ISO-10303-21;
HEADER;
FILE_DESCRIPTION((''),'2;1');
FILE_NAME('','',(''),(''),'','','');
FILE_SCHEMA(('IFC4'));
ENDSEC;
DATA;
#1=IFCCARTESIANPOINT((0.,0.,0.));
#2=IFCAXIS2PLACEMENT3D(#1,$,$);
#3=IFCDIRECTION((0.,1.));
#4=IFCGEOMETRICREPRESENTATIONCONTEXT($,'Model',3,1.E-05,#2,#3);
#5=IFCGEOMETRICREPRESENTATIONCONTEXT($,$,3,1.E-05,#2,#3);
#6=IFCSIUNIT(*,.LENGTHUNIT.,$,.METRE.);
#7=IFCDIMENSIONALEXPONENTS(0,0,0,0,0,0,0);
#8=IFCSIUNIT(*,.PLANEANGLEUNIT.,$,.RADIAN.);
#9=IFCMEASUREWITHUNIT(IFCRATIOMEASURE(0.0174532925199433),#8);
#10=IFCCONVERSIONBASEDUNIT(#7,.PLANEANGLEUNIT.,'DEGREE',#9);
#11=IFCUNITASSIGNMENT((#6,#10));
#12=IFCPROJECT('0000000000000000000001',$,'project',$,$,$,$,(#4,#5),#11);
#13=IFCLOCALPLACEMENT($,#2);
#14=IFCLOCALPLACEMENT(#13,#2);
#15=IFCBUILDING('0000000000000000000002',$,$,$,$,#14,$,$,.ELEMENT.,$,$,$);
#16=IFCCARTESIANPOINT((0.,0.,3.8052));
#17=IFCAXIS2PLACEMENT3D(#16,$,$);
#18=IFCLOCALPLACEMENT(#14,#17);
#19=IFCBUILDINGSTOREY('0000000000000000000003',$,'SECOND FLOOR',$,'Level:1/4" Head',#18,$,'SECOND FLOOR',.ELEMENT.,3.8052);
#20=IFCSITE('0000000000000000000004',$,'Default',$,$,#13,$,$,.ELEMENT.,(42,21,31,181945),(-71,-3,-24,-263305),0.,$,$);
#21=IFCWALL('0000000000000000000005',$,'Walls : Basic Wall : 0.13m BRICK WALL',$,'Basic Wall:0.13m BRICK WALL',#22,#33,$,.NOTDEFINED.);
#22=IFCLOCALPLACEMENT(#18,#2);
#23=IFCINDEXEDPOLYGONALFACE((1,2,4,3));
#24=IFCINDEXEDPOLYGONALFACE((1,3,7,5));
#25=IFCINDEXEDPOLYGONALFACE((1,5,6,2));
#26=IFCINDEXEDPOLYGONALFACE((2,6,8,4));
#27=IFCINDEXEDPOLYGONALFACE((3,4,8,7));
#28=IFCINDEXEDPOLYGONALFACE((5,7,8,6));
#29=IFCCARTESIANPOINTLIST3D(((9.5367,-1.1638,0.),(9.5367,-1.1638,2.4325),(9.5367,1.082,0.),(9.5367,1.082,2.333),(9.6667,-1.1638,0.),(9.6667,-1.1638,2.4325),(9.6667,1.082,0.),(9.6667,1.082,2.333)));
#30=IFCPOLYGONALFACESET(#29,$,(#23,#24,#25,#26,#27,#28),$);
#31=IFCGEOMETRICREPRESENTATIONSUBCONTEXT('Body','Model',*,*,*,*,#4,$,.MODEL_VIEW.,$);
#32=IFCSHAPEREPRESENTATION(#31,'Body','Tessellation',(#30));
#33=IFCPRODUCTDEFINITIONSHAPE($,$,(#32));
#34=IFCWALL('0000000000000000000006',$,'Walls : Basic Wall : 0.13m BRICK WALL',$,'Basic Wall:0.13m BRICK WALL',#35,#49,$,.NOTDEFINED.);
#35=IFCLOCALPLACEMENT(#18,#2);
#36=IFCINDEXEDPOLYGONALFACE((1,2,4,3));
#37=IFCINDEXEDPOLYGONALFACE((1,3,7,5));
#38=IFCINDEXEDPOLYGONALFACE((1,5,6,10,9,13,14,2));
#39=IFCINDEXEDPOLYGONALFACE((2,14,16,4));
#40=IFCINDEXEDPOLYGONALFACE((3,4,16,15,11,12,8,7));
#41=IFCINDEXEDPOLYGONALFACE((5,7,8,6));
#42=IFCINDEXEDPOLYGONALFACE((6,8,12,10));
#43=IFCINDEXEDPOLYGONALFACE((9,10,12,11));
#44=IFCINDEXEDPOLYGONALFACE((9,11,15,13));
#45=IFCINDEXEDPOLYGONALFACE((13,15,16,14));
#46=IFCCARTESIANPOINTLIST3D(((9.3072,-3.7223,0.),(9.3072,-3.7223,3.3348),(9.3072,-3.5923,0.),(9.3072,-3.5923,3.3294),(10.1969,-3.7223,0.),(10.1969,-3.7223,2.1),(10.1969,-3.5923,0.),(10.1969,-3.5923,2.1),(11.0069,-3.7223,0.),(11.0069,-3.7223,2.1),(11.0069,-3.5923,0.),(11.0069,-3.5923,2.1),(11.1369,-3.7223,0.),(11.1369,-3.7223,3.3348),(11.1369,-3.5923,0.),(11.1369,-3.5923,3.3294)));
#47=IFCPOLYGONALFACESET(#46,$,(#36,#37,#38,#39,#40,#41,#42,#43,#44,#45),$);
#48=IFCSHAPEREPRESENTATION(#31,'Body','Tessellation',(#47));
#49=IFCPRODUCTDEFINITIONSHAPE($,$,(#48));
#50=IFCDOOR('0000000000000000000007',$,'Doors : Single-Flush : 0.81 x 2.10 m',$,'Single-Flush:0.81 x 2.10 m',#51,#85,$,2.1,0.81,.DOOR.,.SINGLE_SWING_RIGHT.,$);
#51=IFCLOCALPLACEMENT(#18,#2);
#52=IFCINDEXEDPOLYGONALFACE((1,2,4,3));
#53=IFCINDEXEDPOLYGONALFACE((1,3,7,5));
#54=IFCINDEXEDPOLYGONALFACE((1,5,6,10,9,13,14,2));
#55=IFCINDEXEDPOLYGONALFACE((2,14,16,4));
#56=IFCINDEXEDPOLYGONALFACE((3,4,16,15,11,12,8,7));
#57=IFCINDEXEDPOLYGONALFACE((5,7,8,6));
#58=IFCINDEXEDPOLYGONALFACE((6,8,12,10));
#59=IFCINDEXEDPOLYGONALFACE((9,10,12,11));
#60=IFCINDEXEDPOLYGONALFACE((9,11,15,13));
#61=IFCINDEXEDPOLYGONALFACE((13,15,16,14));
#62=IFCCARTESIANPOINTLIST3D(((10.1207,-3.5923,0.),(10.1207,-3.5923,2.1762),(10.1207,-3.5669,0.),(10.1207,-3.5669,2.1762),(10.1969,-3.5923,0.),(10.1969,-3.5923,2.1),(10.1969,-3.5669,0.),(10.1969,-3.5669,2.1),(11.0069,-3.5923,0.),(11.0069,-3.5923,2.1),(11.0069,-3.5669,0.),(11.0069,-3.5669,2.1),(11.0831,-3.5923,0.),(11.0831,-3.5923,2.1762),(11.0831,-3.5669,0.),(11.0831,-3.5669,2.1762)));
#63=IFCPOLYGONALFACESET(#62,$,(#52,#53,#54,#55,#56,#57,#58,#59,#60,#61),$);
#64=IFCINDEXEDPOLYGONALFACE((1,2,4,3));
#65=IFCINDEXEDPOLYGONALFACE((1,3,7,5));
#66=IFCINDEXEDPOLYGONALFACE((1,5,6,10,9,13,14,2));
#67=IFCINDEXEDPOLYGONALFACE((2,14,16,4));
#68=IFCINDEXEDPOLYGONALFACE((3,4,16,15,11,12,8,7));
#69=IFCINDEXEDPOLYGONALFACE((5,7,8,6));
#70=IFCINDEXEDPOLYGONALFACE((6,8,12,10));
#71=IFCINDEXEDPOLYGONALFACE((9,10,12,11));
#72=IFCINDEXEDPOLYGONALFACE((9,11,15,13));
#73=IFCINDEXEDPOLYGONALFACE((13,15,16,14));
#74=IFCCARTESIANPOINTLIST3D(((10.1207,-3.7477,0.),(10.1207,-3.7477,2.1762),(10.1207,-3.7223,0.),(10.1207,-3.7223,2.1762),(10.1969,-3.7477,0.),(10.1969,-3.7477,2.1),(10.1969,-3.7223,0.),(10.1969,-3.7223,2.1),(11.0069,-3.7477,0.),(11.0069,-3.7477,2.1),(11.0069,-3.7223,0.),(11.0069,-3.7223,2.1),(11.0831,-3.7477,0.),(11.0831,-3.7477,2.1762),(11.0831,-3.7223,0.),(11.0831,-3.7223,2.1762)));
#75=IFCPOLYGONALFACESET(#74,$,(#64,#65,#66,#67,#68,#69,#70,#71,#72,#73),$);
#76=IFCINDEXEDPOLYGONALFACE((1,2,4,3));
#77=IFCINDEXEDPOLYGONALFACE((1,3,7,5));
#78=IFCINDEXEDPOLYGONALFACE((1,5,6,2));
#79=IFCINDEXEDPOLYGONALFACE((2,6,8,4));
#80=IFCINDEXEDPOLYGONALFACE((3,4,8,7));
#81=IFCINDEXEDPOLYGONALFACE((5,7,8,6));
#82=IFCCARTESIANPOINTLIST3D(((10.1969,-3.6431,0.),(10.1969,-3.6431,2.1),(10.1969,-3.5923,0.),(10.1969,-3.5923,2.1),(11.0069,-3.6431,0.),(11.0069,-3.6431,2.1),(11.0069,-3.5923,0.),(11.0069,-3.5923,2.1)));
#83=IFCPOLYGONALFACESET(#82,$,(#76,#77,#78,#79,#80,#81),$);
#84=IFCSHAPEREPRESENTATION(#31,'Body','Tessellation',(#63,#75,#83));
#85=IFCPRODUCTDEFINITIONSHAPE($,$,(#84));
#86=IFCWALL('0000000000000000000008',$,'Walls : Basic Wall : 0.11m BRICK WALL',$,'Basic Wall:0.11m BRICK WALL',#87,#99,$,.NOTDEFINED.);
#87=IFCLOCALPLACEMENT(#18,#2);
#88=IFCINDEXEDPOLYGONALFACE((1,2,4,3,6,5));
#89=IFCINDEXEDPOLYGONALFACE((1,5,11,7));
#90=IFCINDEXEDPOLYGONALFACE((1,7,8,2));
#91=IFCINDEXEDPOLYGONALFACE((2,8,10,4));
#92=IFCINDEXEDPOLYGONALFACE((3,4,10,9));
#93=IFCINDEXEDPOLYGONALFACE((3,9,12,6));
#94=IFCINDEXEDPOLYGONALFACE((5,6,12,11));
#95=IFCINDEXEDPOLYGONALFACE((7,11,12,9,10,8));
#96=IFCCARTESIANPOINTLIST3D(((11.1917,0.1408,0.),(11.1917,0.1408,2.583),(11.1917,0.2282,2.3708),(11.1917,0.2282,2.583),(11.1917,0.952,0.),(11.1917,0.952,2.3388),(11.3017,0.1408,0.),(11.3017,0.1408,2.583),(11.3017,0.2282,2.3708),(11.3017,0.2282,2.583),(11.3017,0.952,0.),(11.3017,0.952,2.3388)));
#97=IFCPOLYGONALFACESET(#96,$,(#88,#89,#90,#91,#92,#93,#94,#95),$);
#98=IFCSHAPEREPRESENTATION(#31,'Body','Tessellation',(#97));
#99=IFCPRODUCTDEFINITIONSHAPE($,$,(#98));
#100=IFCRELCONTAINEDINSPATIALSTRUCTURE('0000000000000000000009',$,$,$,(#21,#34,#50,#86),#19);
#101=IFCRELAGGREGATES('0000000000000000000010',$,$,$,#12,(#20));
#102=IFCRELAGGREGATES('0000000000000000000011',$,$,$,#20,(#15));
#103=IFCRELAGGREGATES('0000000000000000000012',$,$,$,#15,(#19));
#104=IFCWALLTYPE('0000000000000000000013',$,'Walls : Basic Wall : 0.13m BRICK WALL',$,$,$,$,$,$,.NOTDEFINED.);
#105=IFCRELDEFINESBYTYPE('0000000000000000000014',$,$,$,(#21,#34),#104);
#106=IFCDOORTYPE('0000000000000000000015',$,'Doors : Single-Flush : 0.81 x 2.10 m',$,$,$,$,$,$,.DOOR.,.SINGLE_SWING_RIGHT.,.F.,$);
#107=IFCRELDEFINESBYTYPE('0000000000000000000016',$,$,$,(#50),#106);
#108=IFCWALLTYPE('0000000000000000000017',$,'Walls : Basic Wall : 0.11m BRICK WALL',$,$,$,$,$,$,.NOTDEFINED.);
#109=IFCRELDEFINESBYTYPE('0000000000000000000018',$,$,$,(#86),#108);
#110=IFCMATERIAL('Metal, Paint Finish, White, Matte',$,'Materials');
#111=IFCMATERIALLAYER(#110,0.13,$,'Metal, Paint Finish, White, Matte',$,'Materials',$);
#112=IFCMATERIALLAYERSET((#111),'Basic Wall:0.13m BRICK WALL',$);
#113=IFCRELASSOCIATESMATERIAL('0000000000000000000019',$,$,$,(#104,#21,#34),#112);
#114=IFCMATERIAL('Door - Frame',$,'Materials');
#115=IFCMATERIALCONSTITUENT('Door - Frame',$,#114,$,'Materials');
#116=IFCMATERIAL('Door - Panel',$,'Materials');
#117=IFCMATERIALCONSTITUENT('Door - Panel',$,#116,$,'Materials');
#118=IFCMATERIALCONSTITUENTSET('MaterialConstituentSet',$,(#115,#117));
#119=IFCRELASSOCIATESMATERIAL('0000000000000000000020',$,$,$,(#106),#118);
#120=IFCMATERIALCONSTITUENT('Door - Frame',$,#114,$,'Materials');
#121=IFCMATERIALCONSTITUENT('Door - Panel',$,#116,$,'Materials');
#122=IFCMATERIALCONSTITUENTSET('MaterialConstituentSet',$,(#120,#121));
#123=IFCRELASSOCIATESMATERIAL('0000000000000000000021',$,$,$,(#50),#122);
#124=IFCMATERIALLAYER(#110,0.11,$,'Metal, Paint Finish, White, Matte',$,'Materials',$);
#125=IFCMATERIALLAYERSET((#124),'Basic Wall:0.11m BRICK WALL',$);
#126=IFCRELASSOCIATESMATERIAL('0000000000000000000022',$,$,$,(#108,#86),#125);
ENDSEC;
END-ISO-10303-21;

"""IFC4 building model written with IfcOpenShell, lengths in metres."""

from ifc_helpers import new_model, entity, si_unit, converted_unit, direction, frame, frame_2d, origin, place, context, subcontext, project, spatial, polyline, rectangle, outline, extrude, clip, bounded_halfspace, source, transform, mapped, material, layer, layer_set, layer_usage, constituent, constituent_set, type_object, type_shapes, element, fill, save


model = new_model("IFC4")

# Units and contexts
model_context = context("Model", 3, precision=1e-05, world=origin(), true_north=direction((0.0, 1.0)))
context_of_model = context(None, 3, precision=1e-05, world=origin(), true_north=direction((0.0, 1.0)))
body_context = subcontext(model_context, "Body", "Model", "MODEL_VIEW")
ifc_project = project(units=[si_unit("LENGTHUNIT", "METRE"), converted_unit("PLANEANGLEUNIT", "DEGREE", entity("IfcRatioMeasure", 0.0174532925199433), si_unit("PLANEANGLEUNIT", "RADIAN"), dimensions=[0, 0, 0, 0, 0, 0, 0])], contexts=[model_context, context_of_model])

# Site, building, storey
site_placement = place(None, origin())
site = spatial("IfcSite", under=ifc_project, at=site_placement, Name="Default", CompositionType="ELEMENT", RefLatitude=(42, 21, 31, 181945), RefLongitude=(-71, -3, -24, -263305), RefElevation=0.0)
building_placement = place(site_placement, origin())
building = spatial("IfcBuilding", under=site, at=building_placement, CompositionType="ELEMENT")
storey_placement = place(building_placement, frame((0.0, 0.0, 3.8052)))
storey = spatial("IfcBuildingStorey", under=building, at=storey_placement, Name="SECOND FLOOR", ObjectType="Level:1/4\" Head", LongName="SECOND FLOOR", CompositionType="ELEMENT", Elevation=3.8052)

# Wall
ifc_material_1 = material(Name="Metal, Paint Finish, White, Matte", Category="Materials")
ifc_layer_1 = layer(ifc_material_1, 0.13, Name="Metal, Paint Finish, White, Matte", Category="Materials")
ifc_layer_set_1 = layer_set([ifc_layer_1], Name="Basic Wall:0.13m BRICK WALL")
ifc_layer_usage_1 = layer_usage(ifc_layer_set_1, "AXIS2", "NEGATIVE", 0.065)
wall_type_1 = type_object("IfcWallType", Name="Walls : Basic Wall : 0.13m BRICK WALL", PredefinedType="NOTDEFINED", material=ifc_layer_set_1)
wall_1_placement = place(storey_placement, frame((9.6017, 1.082, 0.0), z_axis=(0.0, 0.0, 1.0), x_axis=(0.0, -1.0, 0.0)))
element("IfcWall", 1, at=wall_1_placement, inside=storey, type_object=wall_type_1, material=ifc_layer_usage_1, Name="Walls : Basic Wall : 0.13m BRICK WALL", ObjectType="Basic Wall:0.13m BRICK WALL", PredefinedType="NOTDEFINED", context=body_context, shape_type="Clipping", body=[
    clip(extrude(rectangle(XDim=2.2457, YDim=0.13, at=frame_2d((1.1229, 0.0), x_axis=(-1.0, 0.0))), origin(), (0.0, 0.0, 1.0), 2.4325), bounded_halfspace(frame((0.0, -0.065, 2.333), z_axis=(-0.044281, 0.0, 0.999019), x_axis=(0.0, -1.0, 0.0)), False, frame((0.0, -0.065, 2.333)), polyline([(0.0, 0.0), (2.2457, 0.0), (2.2457, 0.13), (0.13, 0.13), (0.0, 0.13), (0.0, 0.0)]))),
])

# Wall, opening, door
ifc_layer_usage_2 = layer_usage(ifc_layer_set_1, "AXIS2", "NEGATIVE", 0.065)
wall_2_placement = place(storey_placement, frame((11.1369, -3.6573, 0.0), z_axis=(0.0, 0.0, 1.0), x_axis=(-1.0, 0.0, 0.0)))
wall_2 = element("IfcWall", 2, at=wall_2_placement, inside=storey, type_object=wall_type_1, material=ifc_layer_usage_2, Name="Walls : Basic Wall : 0.13m BRICK WALL", ObjectType="Basic Wall:0.13m BRICK WALL", PredefinedType="NOTDEFINED", context=body_context, shape_type="Clipping", body=[
    clip(extrude(rectangle(XDim=1.8297, YDim=0.13, at=frame_2d((0.9149, 0.0), x_axis=(-1.0, 0.0))), origin(), (0.0, 0.0, 1.0), 3.3348), bounded_halfspace(frame((0.0, -0.065, 3.3294), z_axis=(0.0, 0.041435, -0.999141), x_axis=(1.0, 0.0, 0.0)), True, frame((0.0, -0.065, 3.3294)), polyline([(0.0, 0.0), (1.8297, 0.0), (1.8297, 0.13), (0.0, 0.13), (0.0, 0.0)]))),
])
opening_1_placement = place(wall_2_placement, frame((0.94, 0.065, 0.0)))
opening_1 = element("IfcOpeningElement", 3, at=opening_1_placement, cuts=wall_2, ObjectType="Opening", PredefinedType="OPENING", context=body_context, shape_type="SweptSolid", body=[
    extrude(rectangle(XDim=0.81, YDim=2.1, at=frame_2d((1.05, 0.405), x_axis=(0.0, 1.0))), frame((0.0, 0.0, 0.0), z_axis=(0.0, -1.0, 0.0), x_axis=(0.0, 0.0, 1.0)), (0.0, 0.0, 1.0), 0.13),
])
ifc_material_2 = material(Name="Door - Frame", Category="Materials")
ifc_constituent_1 = constituent(ifc_material_2, Name="Door - Frame", Category="Materials")
ifc_material_3 = material(Name="Door - Panel", Category="Materials")
ifc_constituent_2 = constituent(ifc_material_3, Name="Door - Panel", Category="Materials")
ifc_constituent_set_1 = constituent_set(constituents=[ifc_constituent_1, ifc_constituent_2], Name="MaterialConstituentSet")
ifc_constituent_3 = constituent(ifc_material_2, Name="Door - Frame", Category="Materials")
ifc_constituent_4 = constituent(ifc_material_3, Name="Door - Panel", Category="Materials")
ifc_constituent_set_2 = constituent_set(constituents=[ifc_constituent_3, ifc_constituent_4], Name="MaterialConstituentSet")
door_type_1 = type_object("IfcDoorType", Name="Doors : Single-Flush : 0.81 x 2.10 m", OperationType="SINGLE_SWING_RIGHT", ParameterTakesPrecedence=False, PredefinedType="DOOR", material=ifc_constituent_set_2)
shared_shape_1 = source(origin(), body_context, "Body", "SweptSolid", [
    extrude(outline(polyline([(-0.4812, -1.1072), (0.4812, -1.1072), (0.4812, 1.0691), (0.405, 1.0691), (0.405, -1.031), (-0.405, -1.031), (-0.405, 1.0691), (-0.4812, 1.0691), (-0.4812, -1.1072)])), frame((0.405, 0.13, 1.0691), z_axis=(0.0, 1.0, 0.0), x_axis=(1.0, 0.0, 0.0)), (0.0, 0.0, 1.0), 0.0254),
    extrude(outline(polyline([(-1.1072, -0.4812), (1.0691, -0.4812), (1.0691, -0.405), (-1.031, -0.405), (-1.031, 0.405), (1.0691, 0.405), (1.0691, 0.4812), (-1.1072, 0.4812), (-1.1072, -0.4812)])), frame((0.405, -0.0254, 1.0691), z_axis=(0.0, 1.0, 0.0), x_axis=(0.0, 0.0, -1.0)), (0.0, 0.0, 1.0), 0.0254),
    extrude(rectangle(XDim=0.0508, YDim=0.81, at=frame_2d((0.0, 0.0), x_axis=(1.0, 0.0))), frame((0.405, 0.1046, 0.0), z_axis=(0.0, 0.0, 1.0), x_axis=(0.0, 1.0, 0.0)), (0.0, 0.0, 1.0), 2.1),
])
type_shapes(door_type_1, [shared_shape_1])
door_1_placement = place(opening_1_placement, frame((0.0, 0.0, 0.0), z_axis=(0.0, 0.0, 1.0), x_axis=(-1.0, 0.0, 0.0)))
door_1 = element("IfcDoor", 4, at=door_1_placement, inside=storey, type_object=door_type_1, material=ifc_constituent_set_1, Name="Doors : Single-Flush : 0.81 x 2.10 m", ObjectType="Single-Flush:0.81 x 2.10 m", OperationType="SINGLE_SWING_RIGHT", OverallHeight=2.1, OverallWidth=0.81, PredefinedType="DOOR", context=body_context, shape_type="MappedRepresentation", body=[
    mapped(shared_shape_1, transform((0.0, 0.0, 0.0), scale=1.0)),
])
fill(opening_1, door_1)

# Wall
ifc_layer_2 = layer(ifc_material_1, 0.11, Name="Metal, Paint Finish, White, Matte", Category="Materials")
ifc_layer_set_2 = layer_set([ifc_layer_2], Name="Basic Wall:0.11m BRICK WALL")
ifc_layer_usage_3 = layer_usage(ifc_layer_set_2, "AXIS2", "NEGATIVE", 0.055)
wall_type_2 = type_object("IfcWallType", Name="Walls : Basic Wall : 0.11m BRICK WALL", PredefinedType="NOTDEFINED", material=ifc_layer_set_2)
wall_3_placement = place(storey_placement, frame((11.2467, 0.952, 0.0), z_axis=(0.0, 0.0, 1.0), x_axis=(0.0, -1.0, 0.0)))
element("IfcWall", 5, at=wall_3_placement, inside=storey, type_object=wall_type_2, material=ifc_layer_usage_3, Name="Walls : Basic Wall : 0.11m BRICK WALL", ObjectType="Basic Wall:0.11m BRICK WALL", PredefinedType="NOTDEFINED", context=body_context, shape_type="Clipping", body=[
    clip(extrude(rectangle(XDim=0.8112, YDim=0.11, at=frame_2d((0.4056, 0.0), x_axis=(-1.0, 0.0))), origin(), (0.0, 0.0, 1.0), 2.583), bounded_halfspace(frame((0.0, -0.055, 2.3388), z_axis=(-0.044281, 0.0, 0.999019), x_axis=(0.0, -1.0, 0.0)), False, frame((0.0, -0.055, 2.3388)), polyline([(0.0, 0.0), (0.7238, 0.0), (0.7238, 0.11), (0.0, 0.11), (0.0, 0.0)]))),
])

save(model, "model.ifc")
